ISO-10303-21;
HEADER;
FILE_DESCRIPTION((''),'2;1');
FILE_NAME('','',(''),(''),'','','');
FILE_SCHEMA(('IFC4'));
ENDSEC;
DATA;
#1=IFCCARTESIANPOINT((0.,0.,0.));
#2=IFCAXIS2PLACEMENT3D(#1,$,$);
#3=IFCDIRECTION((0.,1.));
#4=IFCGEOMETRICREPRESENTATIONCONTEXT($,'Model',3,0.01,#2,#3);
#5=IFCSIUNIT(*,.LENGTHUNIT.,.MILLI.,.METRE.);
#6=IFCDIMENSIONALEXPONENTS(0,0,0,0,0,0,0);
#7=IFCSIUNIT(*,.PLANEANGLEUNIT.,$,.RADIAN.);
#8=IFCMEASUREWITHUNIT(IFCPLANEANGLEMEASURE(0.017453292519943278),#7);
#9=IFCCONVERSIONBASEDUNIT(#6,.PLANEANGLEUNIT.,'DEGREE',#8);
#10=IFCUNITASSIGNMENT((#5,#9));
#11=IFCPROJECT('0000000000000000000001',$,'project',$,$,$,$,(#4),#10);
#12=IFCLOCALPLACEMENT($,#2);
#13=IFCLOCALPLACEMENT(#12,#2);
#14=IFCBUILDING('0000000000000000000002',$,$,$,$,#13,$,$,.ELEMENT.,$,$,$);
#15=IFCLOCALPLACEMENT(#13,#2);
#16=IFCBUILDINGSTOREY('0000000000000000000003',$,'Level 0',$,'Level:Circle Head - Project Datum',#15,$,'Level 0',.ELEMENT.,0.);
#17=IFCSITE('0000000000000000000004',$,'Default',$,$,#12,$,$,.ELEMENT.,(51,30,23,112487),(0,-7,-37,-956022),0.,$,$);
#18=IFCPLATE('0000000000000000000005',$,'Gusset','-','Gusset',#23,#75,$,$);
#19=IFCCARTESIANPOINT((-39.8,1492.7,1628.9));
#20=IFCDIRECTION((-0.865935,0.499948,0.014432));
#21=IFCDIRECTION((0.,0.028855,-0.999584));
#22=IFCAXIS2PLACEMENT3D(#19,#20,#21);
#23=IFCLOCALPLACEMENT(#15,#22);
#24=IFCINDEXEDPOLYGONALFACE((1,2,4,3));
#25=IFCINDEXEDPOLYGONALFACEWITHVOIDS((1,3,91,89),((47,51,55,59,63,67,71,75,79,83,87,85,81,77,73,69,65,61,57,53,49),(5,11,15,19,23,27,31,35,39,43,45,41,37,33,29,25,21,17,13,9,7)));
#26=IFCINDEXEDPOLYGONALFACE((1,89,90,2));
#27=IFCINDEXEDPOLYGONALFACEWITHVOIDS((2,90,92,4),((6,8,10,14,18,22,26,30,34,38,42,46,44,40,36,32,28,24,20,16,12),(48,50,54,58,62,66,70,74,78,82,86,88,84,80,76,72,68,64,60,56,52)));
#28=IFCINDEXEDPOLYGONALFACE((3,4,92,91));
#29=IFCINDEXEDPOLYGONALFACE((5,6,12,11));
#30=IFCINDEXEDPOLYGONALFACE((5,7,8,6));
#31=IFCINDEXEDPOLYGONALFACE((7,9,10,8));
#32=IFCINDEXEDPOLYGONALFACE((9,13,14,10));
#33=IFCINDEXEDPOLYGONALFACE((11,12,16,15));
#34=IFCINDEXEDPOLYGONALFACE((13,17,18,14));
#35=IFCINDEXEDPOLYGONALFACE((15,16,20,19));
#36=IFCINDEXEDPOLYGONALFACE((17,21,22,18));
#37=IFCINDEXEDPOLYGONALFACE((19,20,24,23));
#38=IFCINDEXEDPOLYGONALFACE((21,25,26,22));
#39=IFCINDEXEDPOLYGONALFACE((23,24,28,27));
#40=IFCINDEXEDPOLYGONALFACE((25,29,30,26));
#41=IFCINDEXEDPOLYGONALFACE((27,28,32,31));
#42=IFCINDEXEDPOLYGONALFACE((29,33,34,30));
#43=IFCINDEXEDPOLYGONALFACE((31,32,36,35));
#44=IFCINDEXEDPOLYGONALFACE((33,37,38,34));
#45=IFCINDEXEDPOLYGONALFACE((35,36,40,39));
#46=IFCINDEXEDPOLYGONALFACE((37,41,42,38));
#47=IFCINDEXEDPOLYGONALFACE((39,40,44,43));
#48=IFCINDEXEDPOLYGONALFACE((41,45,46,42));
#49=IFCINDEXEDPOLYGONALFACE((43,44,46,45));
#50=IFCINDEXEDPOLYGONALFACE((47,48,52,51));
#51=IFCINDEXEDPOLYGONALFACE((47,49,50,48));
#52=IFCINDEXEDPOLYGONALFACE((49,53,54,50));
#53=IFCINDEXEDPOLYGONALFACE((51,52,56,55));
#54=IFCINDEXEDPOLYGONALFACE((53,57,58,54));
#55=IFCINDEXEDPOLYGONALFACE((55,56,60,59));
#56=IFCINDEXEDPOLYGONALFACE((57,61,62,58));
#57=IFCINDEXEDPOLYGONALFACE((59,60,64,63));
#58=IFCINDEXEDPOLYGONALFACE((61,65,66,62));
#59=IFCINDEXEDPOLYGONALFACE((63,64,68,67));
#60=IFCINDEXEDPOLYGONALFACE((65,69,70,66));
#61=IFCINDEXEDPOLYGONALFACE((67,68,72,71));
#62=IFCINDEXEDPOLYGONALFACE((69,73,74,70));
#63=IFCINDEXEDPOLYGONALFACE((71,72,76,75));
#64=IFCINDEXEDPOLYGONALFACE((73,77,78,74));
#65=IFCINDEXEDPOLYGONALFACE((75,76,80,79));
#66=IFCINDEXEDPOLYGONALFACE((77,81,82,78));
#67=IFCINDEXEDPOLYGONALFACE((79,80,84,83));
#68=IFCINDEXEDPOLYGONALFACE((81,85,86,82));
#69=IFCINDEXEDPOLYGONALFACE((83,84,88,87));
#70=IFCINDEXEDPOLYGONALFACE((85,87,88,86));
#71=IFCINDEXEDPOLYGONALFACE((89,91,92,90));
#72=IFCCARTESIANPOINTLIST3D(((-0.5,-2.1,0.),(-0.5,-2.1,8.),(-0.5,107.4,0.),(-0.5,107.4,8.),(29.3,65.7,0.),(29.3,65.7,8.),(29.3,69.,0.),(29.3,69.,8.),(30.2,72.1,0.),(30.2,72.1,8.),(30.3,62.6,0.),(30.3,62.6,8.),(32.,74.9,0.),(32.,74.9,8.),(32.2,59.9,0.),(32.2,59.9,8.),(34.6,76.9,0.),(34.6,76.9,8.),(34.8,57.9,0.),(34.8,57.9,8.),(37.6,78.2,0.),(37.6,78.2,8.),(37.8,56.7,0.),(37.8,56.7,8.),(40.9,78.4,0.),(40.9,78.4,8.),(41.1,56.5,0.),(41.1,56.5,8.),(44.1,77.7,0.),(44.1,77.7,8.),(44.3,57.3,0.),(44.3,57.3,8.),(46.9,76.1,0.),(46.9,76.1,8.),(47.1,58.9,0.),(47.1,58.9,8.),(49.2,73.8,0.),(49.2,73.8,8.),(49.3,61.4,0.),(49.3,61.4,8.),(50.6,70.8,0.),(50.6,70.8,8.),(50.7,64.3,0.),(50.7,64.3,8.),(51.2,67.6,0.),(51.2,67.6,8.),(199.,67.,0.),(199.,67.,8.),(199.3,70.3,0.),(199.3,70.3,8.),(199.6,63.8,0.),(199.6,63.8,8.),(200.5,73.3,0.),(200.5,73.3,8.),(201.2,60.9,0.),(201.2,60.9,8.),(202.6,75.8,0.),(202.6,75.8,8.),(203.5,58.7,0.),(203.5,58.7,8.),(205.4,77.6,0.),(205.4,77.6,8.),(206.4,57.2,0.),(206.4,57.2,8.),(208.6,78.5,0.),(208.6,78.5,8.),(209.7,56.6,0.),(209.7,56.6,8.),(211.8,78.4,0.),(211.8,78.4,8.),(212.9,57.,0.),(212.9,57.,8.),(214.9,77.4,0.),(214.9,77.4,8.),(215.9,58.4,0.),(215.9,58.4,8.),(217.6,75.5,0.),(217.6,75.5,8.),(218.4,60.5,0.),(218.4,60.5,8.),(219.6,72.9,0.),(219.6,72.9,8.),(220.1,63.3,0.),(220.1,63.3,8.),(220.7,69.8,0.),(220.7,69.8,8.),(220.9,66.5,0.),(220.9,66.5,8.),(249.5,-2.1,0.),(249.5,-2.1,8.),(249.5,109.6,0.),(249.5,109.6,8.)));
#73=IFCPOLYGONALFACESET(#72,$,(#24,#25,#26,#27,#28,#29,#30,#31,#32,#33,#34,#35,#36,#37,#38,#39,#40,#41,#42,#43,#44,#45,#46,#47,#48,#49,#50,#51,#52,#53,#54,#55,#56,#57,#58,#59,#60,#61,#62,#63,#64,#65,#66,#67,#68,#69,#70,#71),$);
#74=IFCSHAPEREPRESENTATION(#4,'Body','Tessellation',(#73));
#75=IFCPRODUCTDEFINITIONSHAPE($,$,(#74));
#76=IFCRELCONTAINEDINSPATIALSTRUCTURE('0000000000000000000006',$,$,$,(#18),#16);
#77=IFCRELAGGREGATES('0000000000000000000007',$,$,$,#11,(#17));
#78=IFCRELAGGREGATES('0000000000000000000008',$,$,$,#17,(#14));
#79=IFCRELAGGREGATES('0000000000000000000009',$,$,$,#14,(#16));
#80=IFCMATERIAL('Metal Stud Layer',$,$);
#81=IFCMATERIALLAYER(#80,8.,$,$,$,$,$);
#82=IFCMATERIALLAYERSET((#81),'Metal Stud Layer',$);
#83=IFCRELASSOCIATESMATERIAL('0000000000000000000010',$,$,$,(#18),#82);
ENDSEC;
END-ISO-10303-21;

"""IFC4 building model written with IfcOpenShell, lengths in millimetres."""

from ifc_helpers import new_model, entity, si_unit, converted_unit, direction, frame, origin, origin_with_axes, origin_2d_with_axis, place, context, project, spatial, polyline, circle, outline, extrude, material, layer, layer_set, element, save


model = new_model("IFC4")

# Units and contexts
model_context = context("Model", 3, precision=0.01, world=origin(), true_north=direction((0.0, 1.0)))
ifc_project = project(units=[si_unit("LENGTHUNIT", "METRE", prefix="MILLI"), converted_unit("PLANEANGLEUNIT", "DEGREE", entity("IfcPlaneAngleMeasure", 0.017453292519943278), si_unit("PLANEANGLEUNIT", "RADIAN"), dimensions=[0, 0, 0, 0, 0, 0, 0])], contexts=[model_context])

# Site, building, storey
site_placement = place(None, origin())
site = spatial("IfcSite", under=ifc_project, at=site_placement, Name="Default", CompositionType="ELEMENT", RefLatitude=(51, 30, 23, 112487), RefLongitude=(0, -7, -37, -956022), RefElevation=0.0)
building_placement = place(site_placement, origin())
building = spatial("IfcBuilding", under=site, at=building_placement, CompositionType="ELEMENT")
storey_placement = place(building_placement, origin())
storey = spatial("IfcBuildingStorey", under=building, at=storey_placement, Name="Level 0", ObjectType="Level:Circle Head - Project Datum", LongName="Level 0", CompositionType="ELEMENT", Elevation=0.0)

# Plate, openings
ifc_material = material(Name="Metal Stud Layer")
ifc_layer_1 = layer(ifc_material, 8.0)
ifc_layer_set_1 = layer_set([ifc_layer_1], Name="Metal Stud Layer")
plate_1_placement = place(storey_placement, frame((-39.8, 1492.7, 1628.9), z_axis=(-0.865935, 0.499948, 0.014432), x_axis=(0.0, 0.028855, -0.999584)))
plate_1 = element("IfcPlate", 1, at=plate_1_placement, inside=storey, material=ifc_layer_set_1, Name="Gusset", Description="-", ObjectType="Gusset", context=model_context, shape_type="SweptSolid", body=[
    extrude(outline(polyline([(-0.5, -2.1), (249.5, -2.1), (249.5, 109.6), (-0.5, 107.4), (-0.5, -2.1)])), origin_with_axes(), (0.0, 0.0, 1.0), 8.0),
])
opening_1_placement = place(plate_1_placement, frame((40.2, 67.5, 8.5), z_axis=(0.0, 0.0, -1.0), x_axis=(-0.509076, 0.860722, 0.0)))
element("IfcOpeningElement", 2, at=opening_1_placement, cuts=plate_1, ObjectType="Opening", context=model_context, shape_type="SweptSolid", body=[
    extrude(circle(Radius=11.0, at=origin_2d_with_axis()), origin(), (0.0, 0.0, 1.0), 9.0),
])
opening_2_placement = place(plate_1_placement, frame((209.9, 67.6, 8.5), z_axis=(0.0, 0.0, -1.0), x_axis=(0.455098, 0.890441, 0.0)))
element("IfcOpeningElement", 3, at=opening_2_placement, cuts=plate_1, ObjectType="Opening", context=model_context, shape_type="SweptSolid", body=[
    extrude(circle(Radius=11.0, at=origin_2d_with_axis()), origin(), (0.0, 0.0, 1.0), 9.0),
])

save(model, "model.ifc")
